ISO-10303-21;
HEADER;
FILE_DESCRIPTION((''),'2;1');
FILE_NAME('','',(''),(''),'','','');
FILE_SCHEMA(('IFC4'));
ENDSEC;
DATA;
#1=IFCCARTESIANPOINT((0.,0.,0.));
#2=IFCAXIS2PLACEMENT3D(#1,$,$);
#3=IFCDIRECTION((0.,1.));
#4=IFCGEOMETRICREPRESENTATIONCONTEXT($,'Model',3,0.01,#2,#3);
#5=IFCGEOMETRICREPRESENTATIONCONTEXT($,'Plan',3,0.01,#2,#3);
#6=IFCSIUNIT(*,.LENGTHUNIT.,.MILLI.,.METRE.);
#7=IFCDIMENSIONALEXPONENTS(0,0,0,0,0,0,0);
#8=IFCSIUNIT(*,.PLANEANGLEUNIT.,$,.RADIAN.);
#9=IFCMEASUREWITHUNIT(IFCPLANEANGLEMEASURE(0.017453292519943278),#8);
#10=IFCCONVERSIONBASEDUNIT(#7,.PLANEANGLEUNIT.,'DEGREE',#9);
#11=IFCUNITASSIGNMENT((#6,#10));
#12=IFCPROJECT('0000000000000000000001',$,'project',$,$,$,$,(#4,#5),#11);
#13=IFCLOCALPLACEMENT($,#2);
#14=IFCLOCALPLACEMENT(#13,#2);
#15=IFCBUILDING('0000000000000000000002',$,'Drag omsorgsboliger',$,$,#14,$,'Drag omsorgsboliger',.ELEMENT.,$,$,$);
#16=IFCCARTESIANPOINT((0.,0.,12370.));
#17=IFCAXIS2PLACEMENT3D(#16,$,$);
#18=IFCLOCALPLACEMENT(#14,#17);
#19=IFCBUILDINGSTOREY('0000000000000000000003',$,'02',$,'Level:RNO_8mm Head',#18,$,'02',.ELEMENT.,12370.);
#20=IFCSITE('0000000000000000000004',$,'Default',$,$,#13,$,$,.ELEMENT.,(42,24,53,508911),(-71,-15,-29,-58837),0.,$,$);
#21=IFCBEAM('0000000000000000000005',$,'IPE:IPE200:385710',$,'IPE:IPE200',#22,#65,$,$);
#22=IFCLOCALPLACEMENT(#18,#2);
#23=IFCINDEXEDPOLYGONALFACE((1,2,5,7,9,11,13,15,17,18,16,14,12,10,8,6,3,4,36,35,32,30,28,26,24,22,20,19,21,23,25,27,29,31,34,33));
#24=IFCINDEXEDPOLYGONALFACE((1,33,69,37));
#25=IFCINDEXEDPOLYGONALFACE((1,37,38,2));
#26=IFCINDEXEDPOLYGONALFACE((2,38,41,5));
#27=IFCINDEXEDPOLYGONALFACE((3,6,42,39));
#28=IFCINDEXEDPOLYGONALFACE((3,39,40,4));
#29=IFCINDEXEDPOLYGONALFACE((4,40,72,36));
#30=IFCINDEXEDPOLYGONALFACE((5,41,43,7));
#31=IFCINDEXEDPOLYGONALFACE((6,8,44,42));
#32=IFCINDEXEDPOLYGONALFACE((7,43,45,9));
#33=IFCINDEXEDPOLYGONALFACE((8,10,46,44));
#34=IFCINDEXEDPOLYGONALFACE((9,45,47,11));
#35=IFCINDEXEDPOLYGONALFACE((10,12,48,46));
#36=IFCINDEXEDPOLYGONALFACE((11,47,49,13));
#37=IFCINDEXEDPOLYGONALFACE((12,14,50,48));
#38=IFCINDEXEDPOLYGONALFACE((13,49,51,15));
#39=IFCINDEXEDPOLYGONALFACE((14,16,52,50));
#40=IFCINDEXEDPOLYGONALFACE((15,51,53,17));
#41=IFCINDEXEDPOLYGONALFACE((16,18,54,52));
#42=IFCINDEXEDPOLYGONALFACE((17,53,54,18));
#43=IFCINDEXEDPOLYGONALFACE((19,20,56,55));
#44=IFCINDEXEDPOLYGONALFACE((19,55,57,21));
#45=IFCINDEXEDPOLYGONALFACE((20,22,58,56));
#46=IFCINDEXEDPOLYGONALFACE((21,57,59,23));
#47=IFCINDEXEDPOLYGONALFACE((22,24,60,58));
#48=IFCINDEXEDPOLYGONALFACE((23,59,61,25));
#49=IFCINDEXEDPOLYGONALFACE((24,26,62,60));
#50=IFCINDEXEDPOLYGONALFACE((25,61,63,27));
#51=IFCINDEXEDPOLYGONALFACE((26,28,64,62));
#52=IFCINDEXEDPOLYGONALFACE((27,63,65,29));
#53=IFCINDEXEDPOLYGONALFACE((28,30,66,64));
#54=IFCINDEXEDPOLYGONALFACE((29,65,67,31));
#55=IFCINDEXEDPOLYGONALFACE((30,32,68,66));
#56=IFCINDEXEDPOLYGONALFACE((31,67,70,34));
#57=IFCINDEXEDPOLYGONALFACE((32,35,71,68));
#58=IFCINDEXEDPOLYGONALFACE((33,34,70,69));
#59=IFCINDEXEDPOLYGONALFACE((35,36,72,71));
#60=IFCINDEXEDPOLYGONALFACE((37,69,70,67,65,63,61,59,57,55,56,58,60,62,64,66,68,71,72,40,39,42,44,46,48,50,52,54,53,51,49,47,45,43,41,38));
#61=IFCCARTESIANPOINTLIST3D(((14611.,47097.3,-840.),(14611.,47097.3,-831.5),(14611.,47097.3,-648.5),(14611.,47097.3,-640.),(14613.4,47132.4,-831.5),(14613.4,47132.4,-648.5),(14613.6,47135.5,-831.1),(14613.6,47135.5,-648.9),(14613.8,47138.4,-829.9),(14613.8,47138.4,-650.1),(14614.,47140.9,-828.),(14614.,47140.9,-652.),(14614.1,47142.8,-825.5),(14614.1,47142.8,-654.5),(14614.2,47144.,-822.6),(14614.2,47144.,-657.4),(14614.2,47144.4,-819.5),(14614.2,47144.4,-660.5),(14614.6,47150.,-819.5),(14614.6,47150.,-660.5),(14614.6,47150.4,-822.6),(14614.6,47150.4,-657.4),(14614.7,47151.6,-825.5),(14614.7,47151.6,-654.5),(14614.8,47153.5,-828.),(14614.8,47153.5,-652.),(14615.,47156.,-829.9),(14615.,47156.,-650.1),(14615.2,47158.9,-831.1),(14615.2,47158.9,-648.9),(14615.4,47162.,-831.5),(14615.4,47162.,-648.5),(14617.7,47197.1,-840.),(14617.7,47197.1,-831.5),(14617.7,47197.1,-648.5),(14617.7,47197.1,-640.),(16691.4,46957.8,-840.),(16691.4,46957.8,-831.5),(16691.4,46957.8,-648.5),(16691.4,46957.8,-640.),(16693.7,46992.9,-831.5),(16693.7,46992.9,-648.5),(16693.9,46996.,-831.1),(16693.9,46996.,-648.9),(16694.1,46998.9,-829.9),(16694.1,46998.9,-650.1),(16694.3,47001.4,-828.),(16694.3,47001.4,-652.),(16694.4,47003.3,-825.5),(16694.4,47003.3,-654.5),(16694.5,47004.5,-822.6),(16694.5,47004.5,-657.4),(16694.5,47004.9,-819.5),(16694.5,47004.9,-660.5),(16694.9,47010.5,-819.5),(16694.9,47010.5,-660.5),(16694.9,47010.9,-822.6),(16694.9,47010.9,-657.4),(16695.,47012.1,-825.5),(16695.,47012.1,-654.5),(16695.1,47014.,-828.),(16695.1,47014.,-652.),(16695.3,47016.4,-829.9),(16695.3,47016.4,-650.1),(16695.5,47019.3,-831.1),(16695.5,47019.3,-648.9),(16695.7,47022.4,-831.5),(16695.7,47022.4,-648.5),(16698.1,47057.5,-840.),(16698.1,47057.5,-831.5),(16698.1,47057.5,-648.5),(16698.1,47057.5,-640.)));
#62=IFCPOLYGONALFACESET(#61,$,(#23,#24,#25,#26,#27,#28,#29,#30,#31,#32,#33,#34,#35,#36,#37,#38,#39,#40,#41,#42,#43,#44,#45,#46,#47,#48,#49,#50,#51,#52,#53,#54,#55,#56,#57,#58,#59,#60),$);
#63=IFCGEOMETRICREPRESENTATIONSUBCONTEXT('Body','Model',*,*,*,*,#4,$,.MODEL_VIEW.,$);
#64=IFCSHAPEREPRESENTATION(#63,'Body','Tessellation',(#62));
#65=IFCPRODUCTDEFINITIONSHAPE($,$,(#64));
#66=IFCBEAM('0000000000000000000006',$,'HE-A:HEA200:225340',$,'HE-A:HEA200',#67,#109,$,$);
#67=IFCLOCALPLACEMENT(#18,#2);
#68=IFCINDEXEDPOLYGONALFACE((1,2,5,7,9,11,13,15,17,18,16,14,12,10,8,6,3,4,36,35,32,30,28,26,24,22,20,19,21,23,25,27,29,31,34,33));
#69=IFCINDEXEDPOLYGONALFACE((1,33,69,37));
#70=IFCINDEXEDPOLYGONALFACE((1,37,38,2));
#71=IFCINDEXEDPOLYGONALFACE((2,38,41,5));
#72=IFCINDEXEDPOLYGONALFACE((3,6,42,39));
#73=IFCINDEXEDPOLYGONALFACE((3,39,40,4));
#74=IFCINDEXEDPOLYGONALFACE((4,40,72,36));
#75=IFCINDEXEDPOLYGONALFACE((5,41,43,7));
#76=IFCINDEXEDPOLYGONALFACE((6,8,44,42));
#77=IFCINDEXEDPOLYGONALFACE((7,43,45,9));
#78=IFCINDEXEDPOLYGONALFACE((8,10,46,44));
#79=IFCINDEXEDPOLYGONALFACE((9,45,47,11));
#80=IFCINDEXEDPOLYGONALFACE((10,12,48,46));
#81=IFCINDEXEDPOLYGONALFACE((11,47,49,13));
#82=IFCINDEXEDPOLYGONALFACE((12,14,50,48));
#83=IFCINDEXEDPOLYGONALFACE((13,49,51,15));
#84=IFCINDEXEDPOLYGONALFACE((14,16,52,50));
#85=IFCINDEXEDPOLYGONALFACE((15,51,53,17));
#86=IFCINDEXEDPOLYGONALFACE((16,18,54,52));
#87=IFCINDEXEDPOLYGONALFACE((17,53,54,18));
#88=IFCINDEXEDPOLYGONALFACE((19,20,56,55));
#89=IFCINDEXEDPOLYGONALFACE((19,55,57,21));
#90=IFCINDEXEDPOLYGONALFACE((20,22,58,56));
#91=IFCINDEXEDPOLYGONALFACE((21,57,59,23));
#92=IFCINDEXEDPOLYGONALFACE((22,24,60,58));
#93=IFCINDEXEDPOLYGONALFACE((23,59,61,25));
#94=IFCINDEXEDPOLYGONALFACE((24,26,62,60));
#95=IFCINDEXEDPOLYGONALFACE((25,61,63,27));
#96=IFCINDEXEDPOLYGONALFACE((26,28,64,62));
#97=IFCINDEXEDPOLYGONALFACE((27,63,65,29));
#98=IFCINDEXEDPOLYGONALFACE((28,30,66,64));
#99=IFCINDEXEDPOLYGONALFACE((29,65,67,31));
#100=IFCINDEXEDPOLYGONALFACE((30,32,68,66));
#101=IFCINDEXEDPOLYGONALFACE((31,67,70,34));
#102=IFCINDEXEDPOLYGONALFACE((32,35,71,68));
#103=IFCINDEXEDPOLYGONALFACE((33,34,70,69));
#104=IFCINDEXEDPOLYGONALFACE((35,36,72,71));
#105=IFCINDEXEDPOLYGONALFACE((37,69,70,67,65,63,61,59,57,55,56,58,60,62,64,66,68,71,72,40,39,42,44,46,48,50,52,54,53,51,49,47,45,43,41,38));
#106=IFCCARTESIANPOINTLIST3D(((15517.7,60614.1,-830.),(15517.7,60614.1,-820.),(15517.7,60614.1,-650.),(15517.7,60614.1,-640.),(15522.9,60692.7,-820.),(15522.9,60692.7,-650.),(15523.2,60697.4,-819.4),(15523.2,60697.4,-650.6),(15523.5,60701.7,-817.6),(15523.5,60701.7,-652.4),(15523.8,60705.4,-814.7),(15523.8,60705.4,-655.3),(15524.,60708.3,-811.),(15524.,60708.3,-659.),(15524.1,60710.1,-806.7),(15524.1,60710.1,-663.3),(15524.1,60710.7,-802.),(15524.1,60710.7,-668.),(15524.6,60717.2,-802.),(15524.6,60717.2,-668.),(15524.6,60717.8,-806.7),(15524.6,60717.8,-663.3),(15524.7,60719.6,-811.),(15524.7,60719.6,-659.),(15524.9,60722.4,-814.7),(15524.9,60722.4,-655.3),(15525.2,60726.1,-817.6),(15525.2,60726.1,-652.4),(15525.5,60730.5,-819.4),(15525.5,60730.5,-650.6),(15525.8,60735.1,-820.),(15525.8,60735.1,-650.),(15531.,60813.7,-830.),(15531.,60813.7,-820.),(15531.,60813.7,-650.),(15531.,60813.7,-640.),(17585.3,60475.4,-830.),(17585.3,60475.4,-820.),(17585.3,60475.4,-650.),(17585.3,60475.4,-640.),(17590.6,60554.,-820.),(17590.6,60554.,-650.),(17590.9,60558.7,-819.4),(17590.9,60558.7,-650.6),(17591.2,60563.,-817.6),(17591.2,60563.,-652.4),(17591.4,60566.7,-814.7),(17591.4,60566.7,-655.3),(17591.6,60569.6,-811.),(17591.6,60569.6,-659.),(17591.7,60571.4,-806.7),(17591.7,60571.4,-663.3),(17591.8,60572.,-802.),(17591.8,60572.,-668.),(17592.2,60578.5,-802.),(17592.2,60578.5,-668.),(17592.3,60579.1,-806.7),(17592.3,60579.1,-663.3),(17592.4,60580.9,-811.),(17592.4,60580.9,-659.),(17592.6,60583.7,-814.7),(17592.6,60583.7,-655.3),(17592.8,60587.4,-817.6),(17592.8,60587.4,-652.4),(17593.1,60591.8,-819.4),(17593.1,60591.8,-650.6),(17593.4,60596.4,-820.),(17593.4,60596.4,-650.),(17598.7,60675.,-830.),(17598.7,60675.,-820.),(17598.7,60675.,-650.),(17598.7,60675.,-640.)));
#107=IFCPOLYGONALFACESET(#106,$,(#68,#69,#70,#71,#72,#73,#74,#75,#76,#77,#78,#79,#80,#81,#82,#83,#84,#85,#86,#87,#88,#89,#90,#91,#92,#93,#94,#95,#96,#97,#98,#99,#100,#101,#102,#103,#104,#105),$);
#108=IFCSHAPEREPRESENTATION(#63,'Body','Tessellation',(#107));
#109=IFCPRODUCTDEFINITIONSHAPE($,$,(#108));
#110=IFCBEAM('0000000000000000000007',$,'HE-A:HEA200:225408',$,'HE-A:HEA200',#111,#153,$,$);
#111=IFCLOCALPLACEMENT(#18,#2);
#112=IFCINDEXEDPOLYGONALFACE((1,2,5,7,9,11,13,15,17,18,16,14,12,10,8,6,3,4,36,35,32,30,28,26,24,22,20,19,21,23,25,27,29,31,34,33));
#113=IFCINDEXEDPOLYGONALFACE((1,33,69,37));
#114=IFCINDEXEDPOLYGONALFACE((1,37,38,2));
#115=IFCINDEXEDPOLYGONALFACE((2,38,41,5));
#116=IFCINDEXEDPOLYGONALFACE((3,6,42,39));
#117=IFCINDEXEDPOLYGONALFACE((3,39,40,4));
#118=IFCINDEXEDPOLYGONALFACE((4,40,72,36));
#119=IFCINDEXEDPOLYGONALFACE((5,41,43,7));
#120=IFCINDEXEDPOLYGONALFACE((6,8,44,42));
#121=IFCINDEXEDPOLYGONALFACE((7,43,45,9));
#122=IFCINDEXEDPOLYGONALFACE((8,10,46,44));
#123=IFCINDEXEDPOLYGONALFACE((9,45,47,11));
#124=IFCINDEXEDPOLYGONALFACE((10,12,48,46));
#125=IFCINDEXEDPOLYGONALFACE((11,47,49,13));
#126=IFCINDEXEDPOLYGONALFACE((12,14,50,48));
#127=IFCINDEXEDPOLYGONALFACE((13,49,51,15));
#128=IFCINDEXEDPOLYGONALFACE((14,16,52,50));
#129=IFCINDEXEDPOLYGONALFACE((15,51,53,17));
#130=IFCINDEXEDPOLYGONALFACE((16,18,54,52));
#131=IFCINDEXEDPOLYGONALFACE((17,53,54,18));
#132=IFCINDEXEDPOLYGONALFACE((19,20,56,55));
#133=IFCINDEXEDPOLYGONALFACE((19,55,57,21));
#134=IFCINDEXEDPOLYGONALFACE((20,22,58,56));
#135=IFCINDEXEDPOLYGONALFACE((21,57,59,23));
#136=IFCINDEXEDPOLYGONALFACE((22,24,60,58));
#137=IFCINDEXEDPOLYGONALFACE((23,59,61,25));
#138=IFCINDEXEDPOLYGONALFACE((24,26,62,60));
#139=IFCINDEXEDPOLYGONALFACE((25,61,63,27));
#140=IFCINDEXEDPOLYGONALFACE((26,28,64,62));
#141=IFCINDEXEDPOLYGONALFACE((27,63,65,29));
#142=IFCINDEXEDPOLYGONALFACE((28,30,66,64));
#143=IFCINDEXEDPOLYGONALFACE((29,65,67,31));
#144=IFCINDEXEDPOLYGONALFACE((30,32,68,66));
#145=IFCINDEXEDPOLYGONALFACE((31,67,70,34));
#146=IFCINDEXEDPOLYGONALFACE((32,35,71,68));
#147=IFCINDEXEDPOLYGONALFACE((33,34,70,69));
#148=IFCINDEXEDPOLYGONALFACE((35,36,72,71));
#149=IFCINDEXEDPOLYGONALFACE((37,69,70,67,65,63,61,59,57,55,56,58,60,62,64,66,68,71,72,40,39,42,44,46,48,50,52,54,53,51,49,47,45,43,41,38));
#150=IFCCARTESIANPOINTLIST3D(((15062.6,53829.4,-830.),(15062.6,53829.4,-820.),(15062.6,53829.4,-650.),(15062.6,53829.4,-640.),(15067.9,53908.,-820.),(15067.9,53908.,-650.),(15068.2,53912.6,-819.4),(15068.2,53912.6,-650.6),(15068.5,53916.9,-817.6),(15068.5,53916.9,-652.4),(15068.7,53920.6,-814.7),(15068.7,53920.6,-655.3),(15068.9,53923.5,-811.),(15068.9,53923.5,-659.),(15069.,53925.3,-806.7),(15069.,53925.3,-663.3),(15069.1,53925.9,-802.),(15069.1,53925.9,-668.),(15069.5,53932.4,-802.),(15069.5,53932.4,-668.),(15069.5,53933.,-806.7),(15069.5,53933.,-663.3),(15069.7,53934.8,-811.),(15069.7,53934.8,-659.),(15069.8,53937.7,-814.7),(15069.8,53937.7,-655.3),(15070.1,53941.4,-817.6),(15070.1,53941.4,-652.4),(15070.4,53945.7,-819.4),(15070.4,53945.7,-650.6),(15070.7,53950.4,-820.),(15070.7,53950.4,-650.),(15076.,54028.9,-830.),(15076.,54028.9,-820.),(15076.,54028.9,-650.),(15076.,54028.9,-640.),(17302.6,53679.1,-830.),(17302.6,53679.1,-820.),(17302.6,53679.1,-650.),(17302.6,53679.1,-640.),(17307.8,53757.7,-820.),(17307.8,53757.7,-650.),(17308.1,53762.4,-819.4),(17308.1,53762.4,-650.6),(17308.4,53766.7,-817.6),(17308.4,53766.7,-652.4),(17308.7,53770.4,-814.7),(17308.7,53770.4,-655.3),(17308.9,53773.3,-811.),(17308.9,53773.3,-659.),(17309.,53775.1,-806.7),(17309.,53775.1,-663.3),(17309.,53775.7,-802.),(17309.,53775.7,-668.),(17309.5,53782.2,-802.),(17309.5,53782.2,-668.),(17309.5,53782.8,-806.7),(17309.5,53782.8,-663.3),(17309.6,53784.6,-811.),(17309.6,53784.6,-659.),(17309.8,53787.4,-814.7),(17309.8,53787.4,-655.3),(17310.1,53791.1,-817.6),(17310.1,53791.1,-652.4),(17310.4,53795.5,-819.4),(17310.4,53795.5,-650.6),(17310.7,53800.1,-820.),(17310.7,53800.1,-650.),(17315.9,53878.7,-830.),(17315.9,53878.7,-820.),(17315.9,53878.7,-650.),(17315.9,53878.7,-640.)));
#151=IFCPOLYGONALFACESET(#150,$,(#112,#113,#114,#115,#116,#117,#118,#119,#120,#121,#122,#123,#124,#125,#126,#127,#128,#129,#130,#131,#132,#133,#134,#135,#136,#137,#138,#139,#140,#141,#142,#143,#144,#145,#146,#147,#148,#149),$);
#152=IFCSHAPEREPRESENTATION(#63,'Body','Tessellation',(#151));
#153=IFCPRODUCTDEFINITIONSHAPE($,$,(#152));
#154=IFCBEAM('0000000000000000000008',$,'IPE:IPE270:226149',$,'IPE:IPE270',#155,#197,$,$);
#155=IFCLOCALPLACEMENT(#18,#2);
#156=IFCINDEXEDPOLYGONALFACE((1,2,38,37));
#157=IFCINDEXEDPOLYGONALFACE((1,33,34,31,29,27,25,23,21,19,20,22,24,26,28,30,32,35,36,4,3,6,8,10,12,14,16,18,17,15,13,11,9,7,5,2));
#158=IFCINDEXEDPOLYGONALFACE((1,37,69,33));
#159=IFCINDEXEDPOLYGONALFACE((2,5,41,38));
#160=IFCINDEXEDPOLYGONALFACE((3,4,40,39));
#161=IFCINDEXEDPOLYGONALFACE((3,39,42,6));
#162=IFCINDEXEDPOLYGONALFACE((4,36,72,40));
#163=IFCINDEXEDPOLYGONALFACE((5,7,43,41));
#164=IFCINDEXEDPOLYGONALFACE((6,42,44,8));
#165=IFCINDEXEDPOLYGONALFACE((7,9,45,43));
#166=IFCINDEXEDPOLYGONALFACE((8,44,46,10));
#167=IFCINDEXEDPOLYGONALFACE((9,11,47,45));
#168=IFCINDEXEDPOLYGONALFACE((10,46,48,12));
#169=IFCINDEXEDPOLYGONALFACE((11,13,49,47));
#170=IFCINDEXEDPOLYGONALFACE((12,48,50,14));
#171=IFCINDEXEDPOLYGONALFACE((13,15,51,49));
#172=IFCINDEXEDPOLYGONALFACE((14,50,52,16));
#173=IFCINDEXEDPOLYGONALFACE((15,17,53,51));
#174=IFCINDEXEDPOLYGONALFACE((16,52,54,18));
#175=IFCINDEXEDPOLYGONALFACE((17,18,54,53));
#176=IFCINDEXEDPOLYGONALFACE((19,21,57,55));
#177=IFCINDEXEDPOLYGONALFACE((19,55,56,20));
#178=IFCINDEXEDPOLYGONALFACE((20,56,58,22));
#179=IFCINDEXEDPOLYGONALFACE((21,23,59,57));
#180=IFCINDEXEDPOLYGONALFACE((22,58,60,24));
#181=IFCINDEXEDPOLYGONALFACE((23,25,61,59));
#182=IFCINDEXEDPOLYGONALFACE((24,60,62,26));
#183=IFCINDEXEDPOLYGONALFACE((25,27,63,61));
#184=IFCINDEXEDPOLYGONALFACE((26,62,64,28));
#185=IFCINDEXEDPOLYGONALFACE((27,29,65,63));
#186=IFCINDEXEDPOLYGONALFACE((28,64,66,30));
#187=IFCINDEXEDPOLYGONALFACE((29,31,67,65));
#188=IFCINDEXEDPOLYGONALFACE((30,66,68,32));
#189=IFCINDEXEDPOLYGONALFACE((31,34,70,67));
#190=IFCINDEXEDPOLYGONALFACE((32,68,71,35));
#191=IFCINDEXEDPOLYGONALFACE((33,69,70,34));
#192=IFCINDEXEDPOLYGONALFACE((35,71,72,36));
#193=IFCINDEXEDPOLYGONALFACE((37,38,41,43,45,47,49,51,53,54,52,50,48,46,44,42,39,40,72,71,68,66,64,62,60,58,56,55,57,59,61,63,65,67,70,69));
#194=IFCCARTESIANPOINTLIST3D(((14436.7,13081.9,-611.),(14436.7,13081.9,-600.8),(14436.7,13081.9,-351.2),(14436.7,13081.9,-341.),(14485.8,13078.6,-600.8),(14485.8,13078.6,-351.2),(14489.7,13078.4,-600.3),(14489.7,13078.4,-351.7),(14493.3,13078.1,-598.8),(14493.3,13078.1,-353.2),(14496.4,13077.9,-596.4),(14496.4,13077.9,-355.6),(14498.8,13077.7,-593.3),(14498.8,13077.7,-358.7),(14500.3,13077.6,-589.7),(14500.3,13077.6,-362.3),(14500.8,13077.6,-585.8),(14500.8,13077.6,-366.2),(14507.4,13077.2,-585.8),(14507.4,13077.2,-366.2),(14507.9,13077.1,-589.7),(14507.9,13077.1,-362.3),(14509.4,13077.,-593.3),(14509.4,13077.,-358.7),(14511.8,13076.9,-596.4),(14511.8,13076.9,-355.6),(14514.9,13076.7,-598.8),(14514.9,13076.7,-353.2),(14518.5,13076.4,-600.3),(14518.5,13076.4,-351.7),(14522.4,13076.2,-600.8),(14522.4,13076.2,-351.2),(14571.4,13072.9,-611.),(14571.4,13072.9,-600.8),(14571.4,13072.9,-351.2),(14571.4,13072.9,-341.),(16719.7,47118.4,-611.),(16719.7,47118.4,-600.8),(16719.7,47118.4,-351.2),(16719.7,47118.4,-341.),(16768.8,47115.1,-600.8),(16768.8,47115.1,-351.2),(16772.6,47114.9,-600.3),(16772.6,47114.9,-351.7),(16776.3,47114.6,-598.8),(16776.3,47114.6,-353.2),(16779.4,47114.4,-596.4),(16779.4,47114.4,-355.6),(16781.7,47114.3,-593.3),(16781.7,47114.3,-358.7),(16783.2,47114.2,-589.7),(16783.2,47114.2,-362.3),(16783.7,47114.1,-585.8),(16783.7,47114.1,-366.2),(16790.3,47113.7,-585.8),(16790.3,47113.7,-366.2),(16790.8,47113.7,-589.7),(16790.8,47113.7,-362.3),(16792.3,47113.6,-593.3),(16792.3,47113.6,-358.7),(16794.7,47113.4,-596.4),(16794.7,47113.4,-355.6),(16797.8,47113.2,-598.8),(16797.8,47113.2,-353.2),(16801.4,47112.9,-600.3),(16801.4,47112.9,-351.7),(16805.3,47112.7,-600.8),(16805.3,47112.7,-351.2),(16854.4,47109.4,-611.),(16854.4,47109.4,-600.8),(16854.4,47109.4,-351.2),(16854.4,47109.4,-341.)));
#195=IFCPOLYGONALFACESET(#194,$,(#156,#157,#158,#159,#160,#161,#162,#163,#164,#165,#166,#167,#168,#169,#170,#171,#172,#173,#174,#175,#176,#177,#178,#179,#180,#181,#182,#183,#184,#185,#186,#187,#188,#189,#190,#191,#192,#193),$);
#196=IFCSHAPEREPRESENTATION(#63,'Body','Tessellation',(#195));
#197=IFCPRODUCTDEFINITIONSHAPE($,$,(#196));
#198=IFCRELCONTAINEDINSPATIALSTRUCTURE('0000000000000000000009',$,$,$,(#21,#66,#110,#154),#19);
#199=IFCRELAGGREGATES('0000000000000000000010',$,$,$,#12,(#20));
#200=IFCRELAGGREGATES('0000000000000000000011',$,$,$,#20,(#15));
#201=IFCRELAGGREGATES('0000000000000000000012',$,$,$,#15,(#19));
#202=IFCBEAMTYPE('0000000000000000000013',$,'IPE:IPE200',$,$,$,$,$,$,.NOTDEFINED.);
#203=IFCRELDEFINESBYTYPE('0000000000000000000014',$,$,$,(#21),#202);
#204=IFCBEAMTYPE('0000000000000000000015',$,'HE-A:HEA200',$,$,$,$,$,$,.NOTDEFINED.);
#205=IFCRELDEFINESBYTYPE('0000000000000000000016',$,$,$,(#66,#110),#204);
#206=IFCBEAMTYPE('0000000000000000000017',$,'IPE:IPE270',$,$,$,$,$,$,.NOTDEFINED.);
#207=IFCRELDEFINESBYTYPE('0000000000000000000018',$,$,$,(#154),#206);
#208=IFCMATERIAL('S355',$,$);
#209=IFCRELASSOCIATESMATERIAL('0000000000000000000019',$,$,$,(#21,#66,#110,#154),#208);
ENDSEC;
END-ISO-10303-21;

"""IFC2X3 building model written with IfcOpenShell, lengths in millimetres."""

from ifc_helpers import new_model, entity, si_unit, converted_unit, direction, frame, frame_2d, origin, place, context, subcontext, project, spatial, i_section, extrude, material, type_object, element, save


model = new_model("IFC2X3")

# Units and contexts
model_context = context("Model", 3, precision=0.01, world=origin(), true_north=direction((0.0, 1.0)))
plan_context = context("Plan", 3, precision=0.01, world=origin(), true_north=direction((0.0, 1.0)))
body_context = subcontext(model_context, "Body", "Model", "MODEL_VIEW")
ifc_project = project(units=[si_unit("LENGTHUNIT", "METRE", prefix="MILLI"), converted_unit("PLANEANGLEUNIT", "DEGREE", entity("IfcPlaneAngleMeasure", 0.017453292519943278), si_unit("PLANEANGLEUNIT", "RADIAN"), dimensions=[0, 0, 0, 0, 0, 0, 0])], contexts=[model_context, plan_context])

# Site, building, storey
site_placement = place(None, origin())
site = spatial("IfcSite", under=ifc_project, at=site_placement, Name="Default", CompositionType="ELEMENT", RefLatitude=(42, 24, 53, 508911), RefLongitude=(-71, -15, -29, -58837), RefElevation=0.0)
building_placement = place(site_placement, origin())
building = spatial("IfcBuilding", under=site, at=building_placement, Name="Drag omsorgsboliger", LongName="Drag omsorgsboliger", CompositionType="ELEMENT")
storey_placement = place(building_placement, frame((0.0, 0.0, 12370.0)))
storey = spatial("IfcBuildingStorey", under=building, at=storey_placement, Name="02", ObjectType="Level:RNO_8mm Head", LongName="02", CompositionType="ELEMENT", Elevation=12370.0)

# Beams
ifc_material_1 = material(Name="S355")
beam_type_1 = type_object("IfcBeamType", Name="IPE:IPE200", PredefinedType="NOTDEFINED")
beam_1_placement = place(storey_placement, frame((16709.7, 47006.7, -640.0), z_axis=(0.0, 0.0, 1.0), x_axis=(-0.997758, 0.066923, 0.0)))
element("IfcBeam", 1, at=beam_1_placement, inside=storey, type_object=beam_type_1, material=ifc_material_1, Name="IPE:IPE200:385710", ObjectType="IPE:IPE200", context=body_context, shape_type="SweptSolid", body=[
    extrude(i_section(OverallWidth=100.0, OverallDepth=200.0, WebThickness=5.6, FlangeThickness=8.5, FilletRadius=12.0, at=frame_2d((0.0, 0.0), x_axis=(0.0, 1.0))), frame((15.0, 0.0, -100.0), z_axis=(1.0, 0.0, 0.0), x_axis=(0.0, 0.0, -1.0)), (0.0, 0.0, 1.0), 2085.0),
])
beam_type_2 = type_object("IfcBeamType", Name="HE-A:HEA200", PredefinedType="NOTDEFINED")
beam_2_placement = place(storey_placement, frame((17619.6, 60573.4, -640.0), z_axis=(0.0, 0.0, 1.0), x_axis=(-0.997758, 0.066923, 0.0)))
element("IfcBeam", 2, at=beam_2_placement, inside=storey, type_object=beam_type_2, material=ifc_material_1, Name="HE-A:HEA200:225340", ObjectType="HE-A:HEA200", context=body_context, shape_type="SweptSolid", body=[
    extrude(i_section(OverallWidth=200.0, OverallDepth=190.0, WebThickness=6.5, FlangeThickness=10.0, FilletRadius=18.0, at=frame_2d((0.0, 0.0), x_axis=(0.0, 1.0))), frame((27.7, 0.0, -95.0), z_axis=(1.0, 0.0, 0.0), x_axis=(0.0, 0.0, -1.0)), (0.0, 0.0, 1.0), 2072.3),
])
beam_3_placement = place(storey_placement, frame((17309.2, 53778.9, -640.0), z_axis=(0.0, 0.0, 1.0), x_axis=(-0.997758, 0.066923, 0.0)))
element("IfcBeam", 3, at=beam_3_placement, inside=storey, type_object=beam_type_2, material=ifc_material_1, Name="HE-A:HEA200:225408", ObjectType="HE-A:HEA200", context=body_context, shape_type="SweptSolid", body=[
    extrude(i_section(OverallWidth=200.0, OverallDepth=190.0, WebThickness=6.5, FlangeThickness=10.0, FilletRadius=18.0, at=frame_2d((0.0, 0.0), x_axis=(0.0, 1.0))), frame((0.0, 0.0, -95.0), z_axis=(1.0, 0.0, 0.0), x_axis=(0.0, 0.0, -1.0)), (0.0, 0.0, 1.0), 2245.0),
])
beam_type_3 = type_object("IfcBeamType", Name="IPE:IPE270", PredefinedType="NOTDEFINED")
beam_4_placement = place(storey_placement, frame((16779.3, 46999.2, -341.0), z_axis=(0.0, 0.0, 1.0), x_axis=(-0.066923, -0.997758, 0.0)))
element("IfcBeam", 4, at=beam_4_placement, inside=storey, type_object=beam_type_3, material=ifc_material_1, Name="IPE:IPE270:226149", ObjectType="IPE:IPE270", context=body_context, shape_type="SweptSolid", body=[
    extrude(i_section(OverallWidth=135.0, OverallDepth=270.0, WebThickness=6.6, FlangeThickness=10.2, FilletRadius=15.0, at=frame_2d((0.0, 0.0), x_axis=(0.0, 1.0))), frame((-115.0, 0.0, -135.0), z_axis=(1.0, 0.0, 0.0), x_axis=(0.0, 0.0, -1.0)), (0.0, 0.0, 1.0), 34113.0),
])

save(model, "model.ifc")
